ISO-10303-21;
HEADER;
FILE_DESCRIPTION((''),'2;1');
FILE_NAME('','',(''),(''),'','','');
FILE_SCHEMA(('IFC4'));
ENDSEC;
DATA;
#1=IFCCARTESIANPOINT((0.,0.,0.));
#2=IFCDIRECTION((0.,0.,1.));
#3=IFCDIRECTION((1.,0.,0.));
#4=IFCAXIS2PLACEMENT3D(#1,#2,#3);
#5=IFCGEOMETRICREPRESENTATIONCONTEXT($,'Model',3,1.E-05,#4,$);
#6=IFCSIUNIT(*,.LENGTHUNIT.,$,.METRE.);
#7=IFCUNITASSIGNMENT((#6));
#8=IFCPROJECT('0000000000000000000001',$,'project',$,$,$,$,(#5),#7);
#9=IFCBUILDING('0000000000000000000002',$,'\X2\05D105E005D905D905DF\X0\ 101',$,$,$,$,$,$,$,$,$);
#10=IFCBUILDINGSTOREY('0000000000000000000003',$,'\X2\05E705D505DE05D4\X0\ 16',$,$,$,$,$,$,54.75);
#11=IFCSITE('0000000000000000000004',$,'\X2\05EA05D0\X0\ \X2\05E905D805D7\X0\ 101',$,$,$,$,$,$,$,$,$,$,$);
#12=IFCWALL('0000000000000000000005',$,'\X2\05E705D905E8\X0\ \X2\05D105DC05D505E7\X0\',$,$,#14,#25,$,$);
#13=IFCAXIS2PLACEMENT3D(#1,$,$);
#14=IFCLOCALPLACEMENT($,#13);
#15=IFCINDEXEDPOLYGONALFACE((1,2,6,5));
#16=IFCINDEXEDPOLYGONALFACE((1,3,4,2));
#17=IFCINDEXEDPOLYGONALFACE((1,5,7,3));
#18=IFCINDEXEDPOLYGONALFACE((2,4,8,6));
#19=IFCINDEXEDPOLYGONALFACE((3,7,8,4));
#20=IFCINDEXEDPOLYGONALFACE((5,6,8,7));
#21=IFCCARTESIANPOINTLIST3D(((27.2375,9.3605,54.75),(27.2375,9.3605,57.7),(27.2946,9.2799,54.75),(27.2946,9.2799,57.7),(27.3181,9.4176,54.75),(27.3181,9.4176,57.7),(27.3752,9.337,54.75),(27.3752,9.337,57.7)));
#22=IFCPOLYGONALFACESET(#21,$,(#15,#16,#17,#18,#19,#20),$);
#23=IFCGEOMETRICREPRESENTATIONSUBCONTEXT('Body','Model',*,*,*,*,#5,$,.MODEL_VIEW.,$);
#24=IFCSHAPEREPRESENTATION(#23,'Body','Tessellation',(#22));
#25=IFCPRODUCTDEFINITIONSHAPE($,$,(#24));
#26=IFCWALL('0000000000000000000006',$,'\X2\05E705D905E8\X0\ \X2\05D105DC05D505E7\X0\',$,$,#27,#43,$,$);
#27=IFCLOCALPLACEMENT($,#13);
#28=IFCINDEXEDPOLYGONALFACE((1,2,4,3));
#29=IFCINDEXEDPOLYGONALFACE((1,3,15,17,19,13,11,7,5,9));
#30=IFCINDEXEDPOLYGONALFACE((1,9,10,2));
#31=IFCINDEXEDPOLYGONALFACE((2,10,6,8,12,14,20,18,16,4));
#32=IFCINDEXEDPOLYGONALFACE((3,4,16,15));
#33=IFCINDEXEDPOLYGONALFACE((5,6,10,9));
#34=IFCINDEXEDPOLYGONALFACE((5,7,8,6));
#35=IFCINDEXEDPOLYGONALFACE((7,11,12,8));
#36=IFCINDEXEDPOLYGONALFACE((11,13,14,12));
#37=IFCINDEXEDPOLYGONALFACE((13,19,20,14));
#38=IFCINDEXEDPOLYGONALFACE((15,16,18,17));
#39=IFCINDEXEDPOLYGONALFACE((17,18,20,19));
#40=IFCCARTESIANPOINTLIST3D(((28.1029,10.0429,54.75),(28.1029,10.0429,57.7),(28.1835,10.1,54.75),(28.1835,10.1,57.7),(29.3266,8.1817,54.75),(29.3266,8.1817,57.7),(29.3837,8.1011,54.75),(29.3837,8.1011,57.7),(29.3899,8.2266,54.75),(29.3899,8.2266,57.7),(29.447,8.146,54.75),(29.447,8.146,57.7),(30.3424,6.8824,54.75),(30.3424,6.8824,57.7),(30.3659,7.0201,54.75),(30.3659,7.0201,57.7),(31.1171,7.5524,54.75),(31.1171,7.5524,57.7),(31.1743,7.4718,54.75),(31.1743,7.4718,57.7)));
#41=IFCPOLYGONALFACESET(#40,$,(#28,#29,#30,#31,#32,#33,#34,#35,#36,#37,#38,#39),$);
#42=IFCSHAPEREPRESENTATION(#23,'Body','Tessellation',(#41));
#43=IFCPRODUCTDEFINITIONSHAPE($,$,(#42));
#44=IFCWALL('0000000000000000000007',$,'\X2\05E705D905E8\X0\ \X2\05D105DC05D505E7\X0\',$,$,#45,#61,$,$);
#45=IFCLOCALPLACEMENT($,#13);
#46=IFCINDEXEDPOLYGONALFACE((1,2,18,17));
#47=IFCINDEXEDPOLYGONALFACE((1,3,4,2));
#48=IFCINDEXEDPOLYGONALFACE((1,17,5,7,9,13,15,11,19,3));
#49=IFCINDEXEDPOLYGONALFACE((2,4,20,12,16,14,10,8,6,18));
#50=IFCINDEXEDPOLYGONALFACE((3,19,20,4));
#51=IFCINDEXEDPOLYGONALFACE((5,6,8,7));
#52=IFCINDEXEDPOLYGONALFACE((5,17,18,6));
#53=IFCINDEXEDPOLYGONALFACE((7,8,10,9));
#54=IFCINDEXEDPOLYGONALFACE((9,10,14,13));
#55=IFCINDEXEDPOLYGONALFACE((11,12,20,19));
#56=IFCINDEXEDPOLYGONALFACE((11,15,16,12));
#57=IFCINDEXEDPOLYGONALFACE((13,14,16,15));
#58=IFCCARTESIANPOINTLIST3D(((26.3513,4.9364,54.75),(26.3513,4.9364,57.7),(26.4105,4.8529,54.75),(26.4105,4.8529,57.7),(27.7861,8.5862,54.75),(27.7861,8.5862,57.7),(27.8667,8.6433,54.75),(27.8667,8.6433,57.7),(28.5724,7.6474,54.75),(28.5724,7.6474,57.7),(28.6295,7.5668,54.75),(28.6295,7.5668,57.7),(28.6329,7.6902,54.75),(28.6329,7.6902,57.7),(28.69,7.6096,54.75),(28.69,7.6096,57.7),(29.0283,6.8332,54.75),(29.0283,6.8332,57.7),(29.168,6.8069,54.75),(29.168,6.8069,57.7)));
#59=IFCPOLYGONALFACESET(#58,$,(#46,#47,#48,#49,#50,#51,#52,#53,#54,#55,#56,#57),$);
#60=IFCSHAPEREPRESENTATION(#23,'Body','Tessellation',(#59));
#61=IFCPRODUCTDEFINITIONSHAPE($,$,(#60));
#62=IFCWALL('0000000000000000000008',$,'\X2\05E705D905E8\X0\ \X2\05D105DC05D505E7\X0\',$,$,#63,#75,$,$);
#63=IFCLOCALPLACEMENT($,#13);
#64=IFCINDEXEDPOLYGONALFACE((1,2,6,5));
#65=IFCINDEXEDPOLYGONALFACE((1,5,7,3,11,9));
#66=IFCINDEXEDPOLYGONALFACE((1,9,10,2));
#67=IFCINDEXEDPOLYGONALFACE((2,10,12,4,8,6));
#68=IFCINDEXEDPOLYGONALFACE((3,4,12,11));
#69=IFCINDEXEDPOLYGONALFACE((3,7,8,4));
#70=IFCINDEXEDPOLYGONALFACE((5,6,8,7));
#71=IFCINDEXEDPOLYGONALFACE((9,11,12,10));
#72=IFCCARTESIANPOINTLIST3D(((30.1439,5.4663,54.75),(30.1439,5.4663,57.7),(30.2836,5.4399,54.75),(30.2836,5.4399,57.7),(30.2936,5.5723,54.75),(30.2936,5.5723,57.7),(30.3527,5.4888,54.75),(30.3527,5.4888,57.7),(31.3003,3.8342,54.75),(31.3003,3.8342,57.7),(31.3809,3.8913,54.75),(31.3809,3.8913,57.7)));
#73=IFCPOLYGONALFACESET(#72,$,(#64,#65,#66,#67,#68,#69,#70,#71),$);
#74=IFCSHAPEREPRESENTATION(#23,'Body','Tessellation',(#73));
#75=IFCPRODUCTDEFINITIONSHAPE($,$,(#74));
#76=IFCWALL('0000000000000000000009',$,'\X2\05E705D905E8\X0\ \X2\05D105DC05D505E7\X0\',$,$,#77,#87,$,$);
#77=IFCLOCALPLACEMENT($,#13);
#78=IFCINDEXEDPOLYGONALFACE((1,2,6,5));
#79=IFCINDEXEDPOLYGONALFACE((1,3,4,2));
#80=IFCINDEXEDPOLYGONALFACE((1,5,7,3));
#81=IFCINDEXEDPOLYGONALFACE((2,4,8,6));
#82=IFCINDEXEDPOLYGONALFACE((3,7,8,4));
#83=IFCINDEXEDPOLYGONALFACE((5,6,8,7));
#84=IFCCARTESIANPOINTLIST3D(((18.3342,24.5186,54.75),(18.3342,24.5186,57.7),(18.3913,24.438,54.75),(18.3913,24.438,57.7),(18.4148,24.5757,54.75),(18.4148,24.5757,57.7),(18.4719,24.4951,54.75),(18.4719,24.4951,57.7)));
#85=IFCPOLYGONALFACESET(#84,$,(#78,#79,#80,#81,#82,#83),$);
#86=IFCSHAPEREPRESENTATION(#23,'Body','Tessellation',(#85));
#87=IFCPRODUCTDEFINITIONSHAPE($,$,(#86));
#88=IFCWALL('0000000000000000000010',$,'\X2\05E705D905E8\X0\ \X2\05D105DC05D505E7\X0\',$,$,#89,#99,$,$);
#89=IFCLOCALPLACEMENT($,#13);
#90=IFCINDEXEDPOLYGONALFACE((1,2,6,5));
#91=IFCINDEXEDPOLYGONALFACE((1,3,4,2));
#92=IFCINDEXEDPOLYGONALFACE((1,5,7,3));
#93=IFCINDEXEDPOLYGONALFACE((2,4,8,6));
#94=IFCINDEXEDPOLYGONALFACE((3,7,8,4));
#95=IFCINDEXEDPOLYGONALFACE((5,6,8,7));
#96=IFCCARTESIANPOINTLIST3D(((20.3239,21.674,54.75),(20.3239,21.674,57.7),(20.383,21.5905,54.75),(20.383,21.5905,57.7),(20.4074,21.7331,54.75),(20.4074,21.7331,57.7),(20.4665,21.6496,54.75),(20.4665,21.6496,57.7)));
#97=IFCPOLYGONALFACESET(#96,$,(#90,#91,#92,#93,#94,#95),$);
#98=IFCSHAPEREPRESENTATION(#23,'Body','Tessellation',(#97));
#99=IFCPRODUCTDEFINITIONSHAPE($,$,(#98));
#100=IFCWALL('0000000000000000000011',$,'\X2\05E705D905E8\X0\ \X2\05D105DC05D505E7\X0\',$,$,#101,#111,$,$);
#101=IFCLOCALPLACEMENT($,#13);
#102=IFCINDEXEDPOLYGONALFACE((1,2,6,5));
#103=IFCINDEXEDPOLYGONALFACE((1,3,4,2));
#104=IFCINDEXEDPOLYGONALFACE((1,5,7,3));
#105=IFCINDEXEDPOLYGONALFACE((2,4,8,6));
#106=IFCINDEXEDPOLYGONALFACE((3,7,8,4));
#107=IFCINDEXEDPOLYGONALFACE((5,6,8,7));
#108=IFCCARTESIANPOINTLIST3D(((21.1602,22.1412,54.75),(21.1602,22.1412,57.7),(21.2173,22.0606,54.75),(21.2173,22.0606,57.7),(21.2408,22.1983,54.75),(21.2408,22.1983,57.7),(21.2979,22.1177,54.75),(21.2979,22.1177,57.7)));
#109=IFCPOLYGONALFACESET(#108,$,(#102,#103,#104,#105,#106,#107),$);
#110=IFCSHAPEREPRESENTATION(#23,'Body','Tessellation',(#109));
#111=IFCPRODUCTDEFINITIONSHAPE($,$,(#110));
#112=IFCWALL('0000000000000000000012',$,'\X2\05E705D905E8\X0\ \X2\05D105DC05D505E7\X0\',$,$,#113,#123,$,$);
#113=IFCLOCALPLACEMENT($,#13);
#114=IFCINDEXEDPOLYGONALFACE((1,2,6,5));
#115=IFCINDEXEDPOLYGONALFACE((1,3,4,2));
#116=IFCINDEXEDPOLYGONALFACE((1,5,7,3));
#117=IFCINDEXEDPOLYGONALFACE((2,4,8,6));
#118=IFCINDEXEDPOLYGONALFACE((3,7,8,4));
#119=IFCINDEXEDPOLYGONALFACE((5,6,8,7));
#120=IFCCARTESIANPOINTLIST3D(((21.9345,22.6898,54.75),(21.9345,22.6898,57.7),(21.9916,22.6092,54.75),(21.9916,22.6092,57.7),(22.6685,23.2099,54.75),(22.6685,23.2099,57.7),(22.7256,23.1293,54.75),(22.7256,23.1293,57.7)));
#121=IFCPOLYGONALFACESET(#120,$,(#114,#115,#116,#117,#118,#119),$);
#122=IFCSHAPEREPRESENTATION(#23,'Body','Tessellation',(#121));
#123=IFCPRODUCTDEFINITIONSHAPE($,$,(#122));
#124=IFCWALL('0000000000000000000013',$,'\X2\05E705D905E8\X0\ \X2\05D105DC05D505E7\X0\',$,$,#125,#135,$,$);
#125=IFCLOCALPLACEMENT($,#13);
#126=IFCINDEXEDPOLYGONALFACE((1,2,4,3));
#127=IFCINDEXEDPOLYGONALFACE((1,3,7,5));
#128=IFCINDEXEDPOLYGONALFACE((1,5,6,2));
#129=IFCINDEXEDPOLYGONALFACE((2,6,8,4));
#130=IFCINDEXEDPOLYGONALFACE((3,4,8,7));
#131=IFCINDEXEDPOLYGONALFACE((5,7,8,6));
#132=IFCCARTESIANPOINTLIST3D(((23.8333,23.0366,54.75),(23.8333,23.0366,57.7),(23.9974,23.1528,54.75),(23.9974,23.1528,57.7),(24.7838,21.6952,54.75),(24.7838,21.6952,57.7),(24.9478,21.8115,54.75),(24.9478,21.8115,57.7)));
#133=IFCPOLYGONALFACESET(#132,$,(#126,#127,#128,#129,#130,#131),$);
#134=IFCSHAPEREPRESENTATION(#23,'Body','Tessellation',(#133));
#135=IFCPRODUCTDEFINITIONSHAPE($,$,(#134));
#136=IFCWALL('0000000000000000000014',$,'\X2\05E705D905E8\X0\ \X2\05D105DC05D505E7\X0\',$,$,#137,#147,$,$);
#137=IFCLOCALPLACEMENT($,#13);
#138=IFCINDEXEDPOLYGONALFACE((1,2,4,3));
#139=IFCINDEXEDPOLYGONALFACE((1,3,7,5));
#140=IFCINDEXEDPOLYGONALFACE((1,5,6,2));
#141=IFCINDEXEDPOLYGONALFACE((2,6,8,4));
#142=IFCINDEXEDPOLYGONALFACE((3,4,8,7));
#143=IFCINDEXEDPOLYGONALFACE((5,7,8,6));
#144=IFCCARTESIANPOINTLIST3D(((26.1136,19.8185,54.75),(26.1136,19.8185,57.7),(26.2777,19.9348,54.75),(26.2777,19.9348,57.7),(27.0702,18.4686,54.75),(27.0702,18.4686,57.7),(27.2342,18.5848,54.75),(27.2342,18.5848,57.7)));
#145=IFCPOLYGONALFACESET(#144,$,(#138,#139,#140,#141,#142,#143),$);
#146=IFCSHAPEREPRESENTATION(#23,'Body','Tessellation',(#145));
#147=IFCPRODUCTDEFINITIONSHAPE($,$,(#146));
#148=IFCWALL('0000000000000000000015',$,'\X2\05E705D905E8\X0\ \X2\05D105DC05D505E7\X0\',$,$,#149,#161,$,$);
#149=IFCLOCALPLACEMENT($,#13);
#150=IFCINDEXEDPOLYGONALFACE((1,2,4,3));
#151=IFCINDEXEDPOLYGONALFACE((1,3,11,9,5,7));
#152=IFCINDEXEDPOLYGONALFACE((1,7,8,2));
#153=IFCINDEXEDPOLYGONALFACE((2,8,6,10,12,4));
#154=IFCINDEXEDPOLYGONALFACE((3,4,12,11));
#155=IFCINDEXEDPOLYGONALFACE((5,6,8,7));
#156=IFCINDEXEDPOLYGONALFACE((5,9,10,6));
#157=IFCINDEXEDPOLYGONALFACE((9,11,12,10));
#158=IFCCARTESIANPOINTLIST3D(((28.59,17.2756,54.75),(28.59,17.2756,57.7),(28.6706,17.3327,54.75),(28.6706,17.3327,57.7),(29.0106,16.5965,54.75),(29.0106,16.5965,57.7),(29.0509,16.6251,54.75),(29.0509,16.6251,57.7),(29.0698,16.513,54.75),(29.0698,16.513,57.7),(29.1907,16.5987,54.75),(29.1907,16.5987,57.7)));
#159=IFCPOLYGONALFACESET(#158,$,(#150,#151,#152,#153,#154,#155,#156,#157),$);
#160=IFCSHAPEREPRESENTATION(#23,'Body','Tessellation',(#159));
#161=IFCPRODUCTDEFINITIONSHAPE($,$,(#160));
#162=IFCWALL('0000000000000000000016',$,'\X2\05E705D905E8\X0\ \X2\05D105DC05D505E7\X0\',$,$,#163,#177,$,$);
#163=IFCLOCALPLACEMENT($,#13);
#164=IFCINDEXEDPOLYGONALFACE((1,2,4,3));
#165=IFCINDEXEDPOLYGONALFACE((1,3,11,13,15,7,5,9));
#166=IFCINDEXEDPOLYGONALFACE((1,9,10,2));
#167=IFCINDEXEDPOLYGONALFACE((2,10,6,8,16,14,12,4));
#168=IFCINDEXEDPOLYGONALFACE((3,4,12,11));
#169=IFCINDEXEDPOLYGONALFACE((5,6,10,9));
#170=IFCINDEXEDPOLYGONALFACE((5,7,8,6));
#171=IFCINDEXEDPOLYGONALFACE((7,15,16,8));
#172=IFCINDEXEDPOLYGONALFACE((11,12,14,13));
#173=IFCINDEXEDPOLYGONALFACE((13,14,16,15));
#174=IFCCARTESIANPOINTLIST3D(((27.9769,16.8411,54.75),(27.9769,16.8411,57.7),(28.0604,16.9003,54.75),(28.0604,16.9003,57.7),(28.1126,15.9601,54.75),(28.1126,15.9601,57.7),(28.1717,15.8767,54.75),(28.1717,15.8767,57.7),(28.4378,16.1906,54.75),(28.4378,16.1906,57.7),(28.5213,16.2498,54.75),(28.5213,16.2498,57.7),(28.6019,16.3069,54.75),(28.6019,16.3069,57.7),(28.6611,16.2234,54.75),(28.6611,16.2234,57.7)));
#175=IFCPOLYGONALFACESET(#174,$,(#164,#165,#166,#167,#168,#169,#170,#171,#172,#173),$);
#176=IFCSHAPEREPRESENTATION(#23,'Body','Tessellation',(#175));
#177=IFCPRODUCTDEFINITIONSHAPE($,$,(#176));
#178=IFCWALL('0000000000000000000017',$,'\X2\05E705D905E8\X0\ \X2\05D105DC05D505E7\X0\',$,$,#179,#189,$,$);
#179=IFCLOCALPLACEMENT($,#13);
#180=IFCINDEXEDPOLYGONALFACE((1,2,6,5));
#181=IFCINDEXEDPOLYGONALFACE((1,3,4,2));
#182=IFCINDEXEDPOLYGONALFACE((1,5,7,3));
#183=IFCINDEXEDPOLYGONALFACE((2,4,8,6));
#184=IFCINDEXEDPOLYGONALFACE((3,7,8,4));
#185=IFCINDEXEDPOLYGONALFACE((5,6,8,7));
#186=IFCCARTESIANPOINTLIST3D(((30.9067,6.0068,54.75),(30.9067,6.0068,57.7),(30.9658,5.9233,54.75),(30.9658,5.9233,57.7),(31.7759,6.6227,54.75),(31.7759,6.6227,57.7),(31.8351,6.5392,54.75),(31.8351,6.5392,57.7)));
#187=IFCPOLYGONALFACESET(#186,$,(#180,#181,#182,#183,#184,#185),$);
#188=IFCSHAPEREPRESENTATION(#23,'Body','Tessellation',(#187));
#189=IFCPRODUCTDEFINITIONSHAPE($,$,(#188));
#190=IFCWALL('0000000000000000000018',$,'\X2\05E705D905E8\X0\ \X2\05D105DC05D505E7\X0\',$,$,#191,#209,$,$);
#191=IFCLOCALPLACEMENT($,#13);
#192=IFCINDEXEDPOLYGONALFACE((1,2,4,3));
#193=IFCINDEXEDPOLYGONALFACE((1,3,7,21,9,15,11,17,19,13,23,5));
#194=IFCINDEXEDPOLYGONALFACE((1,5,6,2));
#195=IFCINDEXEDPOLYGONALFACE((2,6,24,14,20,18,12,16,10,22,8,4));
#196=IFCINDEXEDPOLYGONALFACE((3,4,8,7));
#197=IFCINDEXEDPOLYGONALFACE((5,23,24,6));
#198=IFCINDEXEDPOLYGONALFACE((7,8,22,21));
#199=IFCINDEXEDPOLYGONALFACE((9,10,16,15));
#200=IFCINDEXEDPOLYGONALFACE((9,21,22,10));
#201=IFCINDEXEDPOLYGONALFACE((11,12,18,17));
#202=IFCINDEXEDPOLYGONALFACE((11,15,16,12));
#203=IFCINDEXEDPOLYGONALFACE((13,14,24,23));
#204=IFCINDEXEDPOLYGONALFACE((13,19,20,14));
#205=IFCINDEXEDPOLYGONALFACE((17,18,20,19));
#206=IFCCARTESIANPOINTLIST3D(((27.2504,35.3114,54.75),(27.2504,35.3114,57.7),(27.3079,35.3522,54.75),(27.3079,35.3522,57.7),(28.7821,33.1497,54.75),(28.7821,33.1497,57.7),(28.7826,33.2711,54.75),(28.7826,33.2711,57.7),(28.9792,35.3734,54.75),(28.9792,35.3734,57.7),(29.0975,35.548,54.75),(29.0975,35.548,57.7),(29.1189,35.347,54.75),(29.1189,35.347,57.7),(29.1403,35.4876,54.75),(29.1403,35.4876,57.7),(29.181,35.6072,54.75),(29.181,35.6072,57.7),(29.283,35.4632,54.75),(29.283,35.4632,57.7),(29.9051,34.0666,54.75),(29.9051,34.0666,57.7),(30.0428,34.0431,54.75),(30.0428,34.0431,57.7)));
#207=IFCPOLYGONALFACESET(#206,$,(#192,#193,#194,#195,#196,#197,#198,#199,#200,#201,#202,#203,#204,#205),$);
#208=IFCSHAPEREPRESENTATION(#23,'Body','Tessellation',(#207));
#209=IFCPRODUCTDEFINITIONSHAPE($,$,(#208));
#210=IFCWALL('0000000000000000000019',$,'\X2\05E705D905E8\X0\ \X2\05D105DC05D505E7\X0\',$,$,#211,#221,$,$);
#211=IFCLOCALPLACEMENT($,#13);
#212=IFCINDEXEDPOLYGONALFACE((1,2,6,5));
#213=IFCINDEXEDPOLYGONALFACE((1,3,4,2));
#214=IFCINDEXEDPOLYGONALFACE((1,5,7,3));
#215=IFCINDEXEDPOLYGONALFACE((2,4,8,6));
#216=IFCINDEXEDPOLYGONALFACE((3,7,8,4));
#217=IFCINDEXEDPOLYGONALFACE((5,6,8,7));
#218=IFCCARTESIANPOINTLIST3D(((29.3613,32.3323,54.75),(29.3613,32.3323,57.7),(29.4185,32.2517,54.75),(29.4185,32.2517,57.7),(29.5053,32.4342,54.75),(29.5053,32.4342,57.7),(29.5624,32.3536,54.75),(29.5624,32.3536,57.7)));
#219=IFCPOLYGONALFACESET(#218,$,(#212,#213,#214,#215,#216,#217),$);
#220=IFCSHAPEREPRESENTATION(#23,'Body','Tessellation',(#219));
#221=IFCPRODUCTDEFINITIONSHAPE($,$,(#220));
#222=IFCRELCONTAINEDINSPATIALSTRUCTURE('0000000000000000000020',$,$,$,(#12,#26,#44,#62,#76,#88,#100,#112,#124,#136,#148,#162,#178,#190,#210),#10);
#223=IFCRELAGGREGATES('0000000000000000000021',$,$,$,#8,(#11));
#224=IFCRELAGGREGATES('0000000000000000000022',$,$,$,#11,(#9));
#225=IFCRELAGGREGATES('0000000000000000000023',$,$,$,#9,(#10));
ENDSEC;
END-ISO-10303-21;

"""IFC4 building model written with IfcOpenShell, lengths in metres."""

from ifc_helpers import new_model, si_unit, frame, origin_with_axes, context, subcontext, project, spatial, polyline, outline, extrude, element, save


model = new_model("IFC4")

# Units and contexts
model_context = context("Model", 3, precision=1e-05, world=origin_with_axes())
body_context = subcontext(model_context, "Body", "Model", "MODEL_VIEW")
ifc_project = project(units=[si_unit("LENGTHUNIT", "METRE")], contexts=[model_context])

# Site, building, storey
site = spatial("IfcSite", under=ifc_project, Name="תא שטח 101")
building = spatial("IfcBuilding", under=site, Name="בניין 101")
storey = spatial("IfcBuildingStorey", under=building, Name="קומה 16", Elevation=54.75)

# Walls
element("IfcWall", 1, inside=storey, Name="קיר בלוק", context=body_context, shape_type="SweptSolid", body=[
    extrude(outline(polyline([(27.3181, 9.4176), (27.2375, 9.3605), (27.2946, 9.2799), (27.3752, 9.337), (27.3181, 9.4176)])), frame((0.0, 0.0, 54.75)), (0.0, 0.0, 1.0), 2.95),
])
element("IfcWall", 2, inside=storey, Name="קיר בלוק", context=body_context, shape_type="SweptSolid", body=[
    extrude(outline(polyline([(29.3266, 8.1817), (29.3837, 8.1011), (29.447, 8.146), (30.3424, 6.8824), (31.1743, 7.4718), (31.1171, 7.5524), (30.3659, 7.0201), (28.1835, 10.1), (28.1029, 10.0429), (29.3899, 8.2266), (29.3266, 8.1817)])), frame((0.0, 0.0, 54.75)), (0.0, 0.0, 1.0), 2.95),
])
element("IfcWall", 3, inside=storey, Name="קיר בלוק", context=body_context, shape_type="SweptSolid", body=[
    extrude(outline(polyline([(26.4105, 4.8529), (29.168, 6.8069), (28.6295, 7.5668), (28.69, 7.6096), (28.6329, 7.6902), (28.5724, 7.6474), (27.8667, 8.6433), (27.7861, 8.5862), (29.0283, 6.8332), (26.3513, 4.9364), (26.4105, 4.8529)])), frame((0.0, 0.0, 54.75)), (0.0, 0.0, 1.0), 2.95),
])
element("IfcWall", 4, inside=storey, Name="קיר בלוק", context=body_context, shape_type="SweptSolid", body=[
    extrude(outline(polyline([(30.2836, 5.4399), (30.3527, 5.4888), (30.2936, 5.5723), (30.1439, 5.4663), (31.3003, 3.8342), (31.3809, 3.8913), (30.2836, 5.4399)])), frame((0.0, 0.0, 54.75)), (0.0, 0.0, 1.0), 2.95),
])
element("IfcWall", 5, inside=storey, Name="קיר בלוק", context=body_context, shape_type="SweptSolid", body=[
    extrude(outline(polyline([(18.3913, 24.438), (18.4719, 24.4951), (18.4148, 24.5757), (18.3342, 24.5186), (18.3913, 24.438)])), frame((0.0, 0.0, 54.75)), (0.0, 0.0, 1.0), 2.95),
])
element("IfcWall", 6, inside=storey, Name="קיר בלוק", context=body_context, shape_type="SweptSolid", body=[
    extrude(outline(polyline([(20.4074, 21.7331), (20.3239, 21.674), (20.383, 21.5905), (20.4665, 21.6496), (20.4074, 21.7331)])), frame((0.0, 0.0, 54.75)), (0.0, 0.0, 1.0), 2.95),
])
element("IfcWall", 7, inside=storey, Name="קיר בלוק", context=body_context, shape_type="SweptSolid", body=[
    extrude(outline(polyline([(21.2979, 22.1177), (21.2408, 22.1983), (21.1602, 22.1412), (21.2173, 22.0606), (21.2979, 22.1177)])), frame((0.0, 0.0, 54.75)), (0.0, 0.0, 1.0), 2.95),
])
element("IfcWall", 8, inside=storey, Name="קיר בלוק", context=body_context, shape_type="SweptSolid", body=[
    extrude(outline(polyline([(22.7256, 23.1293), (22.6685, 23.2099), (21.9345, 22.6898), (21.9916, 22.6092), (22.7256, 23.1293)])), frame((0.0, 0.0, 54.75)), (0.0, 0.0, 1.0), 2.95),
])
element("IfcWall", 9, inside=storey, Name="קיר בלוק", context=body_context, shape_type="SweptSolid", body=[
    extrude(outline(polyline([(23.9974, 23.1528), (23.8333, 23.0366), (24.7838, 21.6952), (24.9478, 21.8115), (23.9974, 23.1528)])), frame((0.0, 0.0, 54.75)), (0.0, 0.0, 1.0), 2.95),
])
element("IfcWall", 10, inside=storey, Name="קיר בלוק", context=body_context, shape_type="SweptSolid", body=[
    extrude(outline(polyline([(27.0702, 18.4686), (27.2342, 18.5848), (26.2777, 19.9348), (26.1136, 19.8185), (27.0702, 18.4686)])), frame((0.0, 0.0, 54.75)), (0.0, 0.0, 1.0), 2.95),
])
element("IfcWall", 11, inside=storey, Name="קיר בלוק", context=body_context, shape_type="SweptSolid", body=[
    extrude(outline(polyline([(29.0106, 16.5965), (29.0698, 16.513), (29.1907, 16.5987), (28.6706, 17.3327), (28.59, 17.2756), (29.0509, 16.6251), (29.0106, 16.5965)])), frame((0.0, 0.0, 54.75)), (0.0, 0.0, 1.0), 2.95),
])
element("IfcWall", 12, inside=storey, Name="קיר בלוק", context=body_context, shape_type="SweptSolid", body=[
    extrude(outline(polyline([(28.1717, 15.8767), (28.6611, 16.2234), (28.6019, 16.3069), (28.5213, 16.2498), (28.0604, 16.9003), (27.9769, 16.8411), (28.4378, 16.1906), (28.1126, 15.9601), (28.1717, 15.8767)])), frame((0.0, 0.0, 54.75)), (0.0, 0.0, 1.0), 2.95),
])
element("IfcWall", 13, inside=storey, Name="קיר בלוק", context=body_context, shape_type="SweptSolid", body=[
    extrude(outline(polyline([(31.7759, 6.6227), (30.9067, 6.0068), (30.9658, 5.9233), (31.8351, 6.5392), (31.7759, 6.6227)])), frame((0.0, 0.0, 54.75)), (0.0, 0.0, 1.0), 2.95),
])
element("IfcWall", 14, inside=storey, Name="קיר בלוק", context=body_context, shape_type="SweptSolid", body=[
    extrude(outline(polyline([(27.2504, 35.3114), (28.7821, 33.1497), (30.0428, 34.0431), (29.1189, 35.347), (29.283, 35.4632), (29.181, 35.6072), (29.0975, 35.548), (29.1403, 35.4876), (28.9792, 35.3734), (29.9051, 34.0666), (28.7826, 33.2711), (27.3079, 35.3522), (27.2504, 35.3114)])), frame((0.0, 0.0, 54.75)), (0.0, 0.0, 1.0), 2.95),
])
element("IfcWall", 15, inside=storey, Name="קיר בלוק", context=body_context, shape_type="SweptSolid", body=[
    extrude(outline(polyline([(29.3613, 32.3323), (29.4185, 32.2517), (29.5624, 32.3536), (29.5053, 32.4342), (29.3613, 32.3323)])), frame((0.0, 0.0, 54.75)), (0.0, 0.0, 1.0), 2.95),
])

save(model, "model.ifc")
